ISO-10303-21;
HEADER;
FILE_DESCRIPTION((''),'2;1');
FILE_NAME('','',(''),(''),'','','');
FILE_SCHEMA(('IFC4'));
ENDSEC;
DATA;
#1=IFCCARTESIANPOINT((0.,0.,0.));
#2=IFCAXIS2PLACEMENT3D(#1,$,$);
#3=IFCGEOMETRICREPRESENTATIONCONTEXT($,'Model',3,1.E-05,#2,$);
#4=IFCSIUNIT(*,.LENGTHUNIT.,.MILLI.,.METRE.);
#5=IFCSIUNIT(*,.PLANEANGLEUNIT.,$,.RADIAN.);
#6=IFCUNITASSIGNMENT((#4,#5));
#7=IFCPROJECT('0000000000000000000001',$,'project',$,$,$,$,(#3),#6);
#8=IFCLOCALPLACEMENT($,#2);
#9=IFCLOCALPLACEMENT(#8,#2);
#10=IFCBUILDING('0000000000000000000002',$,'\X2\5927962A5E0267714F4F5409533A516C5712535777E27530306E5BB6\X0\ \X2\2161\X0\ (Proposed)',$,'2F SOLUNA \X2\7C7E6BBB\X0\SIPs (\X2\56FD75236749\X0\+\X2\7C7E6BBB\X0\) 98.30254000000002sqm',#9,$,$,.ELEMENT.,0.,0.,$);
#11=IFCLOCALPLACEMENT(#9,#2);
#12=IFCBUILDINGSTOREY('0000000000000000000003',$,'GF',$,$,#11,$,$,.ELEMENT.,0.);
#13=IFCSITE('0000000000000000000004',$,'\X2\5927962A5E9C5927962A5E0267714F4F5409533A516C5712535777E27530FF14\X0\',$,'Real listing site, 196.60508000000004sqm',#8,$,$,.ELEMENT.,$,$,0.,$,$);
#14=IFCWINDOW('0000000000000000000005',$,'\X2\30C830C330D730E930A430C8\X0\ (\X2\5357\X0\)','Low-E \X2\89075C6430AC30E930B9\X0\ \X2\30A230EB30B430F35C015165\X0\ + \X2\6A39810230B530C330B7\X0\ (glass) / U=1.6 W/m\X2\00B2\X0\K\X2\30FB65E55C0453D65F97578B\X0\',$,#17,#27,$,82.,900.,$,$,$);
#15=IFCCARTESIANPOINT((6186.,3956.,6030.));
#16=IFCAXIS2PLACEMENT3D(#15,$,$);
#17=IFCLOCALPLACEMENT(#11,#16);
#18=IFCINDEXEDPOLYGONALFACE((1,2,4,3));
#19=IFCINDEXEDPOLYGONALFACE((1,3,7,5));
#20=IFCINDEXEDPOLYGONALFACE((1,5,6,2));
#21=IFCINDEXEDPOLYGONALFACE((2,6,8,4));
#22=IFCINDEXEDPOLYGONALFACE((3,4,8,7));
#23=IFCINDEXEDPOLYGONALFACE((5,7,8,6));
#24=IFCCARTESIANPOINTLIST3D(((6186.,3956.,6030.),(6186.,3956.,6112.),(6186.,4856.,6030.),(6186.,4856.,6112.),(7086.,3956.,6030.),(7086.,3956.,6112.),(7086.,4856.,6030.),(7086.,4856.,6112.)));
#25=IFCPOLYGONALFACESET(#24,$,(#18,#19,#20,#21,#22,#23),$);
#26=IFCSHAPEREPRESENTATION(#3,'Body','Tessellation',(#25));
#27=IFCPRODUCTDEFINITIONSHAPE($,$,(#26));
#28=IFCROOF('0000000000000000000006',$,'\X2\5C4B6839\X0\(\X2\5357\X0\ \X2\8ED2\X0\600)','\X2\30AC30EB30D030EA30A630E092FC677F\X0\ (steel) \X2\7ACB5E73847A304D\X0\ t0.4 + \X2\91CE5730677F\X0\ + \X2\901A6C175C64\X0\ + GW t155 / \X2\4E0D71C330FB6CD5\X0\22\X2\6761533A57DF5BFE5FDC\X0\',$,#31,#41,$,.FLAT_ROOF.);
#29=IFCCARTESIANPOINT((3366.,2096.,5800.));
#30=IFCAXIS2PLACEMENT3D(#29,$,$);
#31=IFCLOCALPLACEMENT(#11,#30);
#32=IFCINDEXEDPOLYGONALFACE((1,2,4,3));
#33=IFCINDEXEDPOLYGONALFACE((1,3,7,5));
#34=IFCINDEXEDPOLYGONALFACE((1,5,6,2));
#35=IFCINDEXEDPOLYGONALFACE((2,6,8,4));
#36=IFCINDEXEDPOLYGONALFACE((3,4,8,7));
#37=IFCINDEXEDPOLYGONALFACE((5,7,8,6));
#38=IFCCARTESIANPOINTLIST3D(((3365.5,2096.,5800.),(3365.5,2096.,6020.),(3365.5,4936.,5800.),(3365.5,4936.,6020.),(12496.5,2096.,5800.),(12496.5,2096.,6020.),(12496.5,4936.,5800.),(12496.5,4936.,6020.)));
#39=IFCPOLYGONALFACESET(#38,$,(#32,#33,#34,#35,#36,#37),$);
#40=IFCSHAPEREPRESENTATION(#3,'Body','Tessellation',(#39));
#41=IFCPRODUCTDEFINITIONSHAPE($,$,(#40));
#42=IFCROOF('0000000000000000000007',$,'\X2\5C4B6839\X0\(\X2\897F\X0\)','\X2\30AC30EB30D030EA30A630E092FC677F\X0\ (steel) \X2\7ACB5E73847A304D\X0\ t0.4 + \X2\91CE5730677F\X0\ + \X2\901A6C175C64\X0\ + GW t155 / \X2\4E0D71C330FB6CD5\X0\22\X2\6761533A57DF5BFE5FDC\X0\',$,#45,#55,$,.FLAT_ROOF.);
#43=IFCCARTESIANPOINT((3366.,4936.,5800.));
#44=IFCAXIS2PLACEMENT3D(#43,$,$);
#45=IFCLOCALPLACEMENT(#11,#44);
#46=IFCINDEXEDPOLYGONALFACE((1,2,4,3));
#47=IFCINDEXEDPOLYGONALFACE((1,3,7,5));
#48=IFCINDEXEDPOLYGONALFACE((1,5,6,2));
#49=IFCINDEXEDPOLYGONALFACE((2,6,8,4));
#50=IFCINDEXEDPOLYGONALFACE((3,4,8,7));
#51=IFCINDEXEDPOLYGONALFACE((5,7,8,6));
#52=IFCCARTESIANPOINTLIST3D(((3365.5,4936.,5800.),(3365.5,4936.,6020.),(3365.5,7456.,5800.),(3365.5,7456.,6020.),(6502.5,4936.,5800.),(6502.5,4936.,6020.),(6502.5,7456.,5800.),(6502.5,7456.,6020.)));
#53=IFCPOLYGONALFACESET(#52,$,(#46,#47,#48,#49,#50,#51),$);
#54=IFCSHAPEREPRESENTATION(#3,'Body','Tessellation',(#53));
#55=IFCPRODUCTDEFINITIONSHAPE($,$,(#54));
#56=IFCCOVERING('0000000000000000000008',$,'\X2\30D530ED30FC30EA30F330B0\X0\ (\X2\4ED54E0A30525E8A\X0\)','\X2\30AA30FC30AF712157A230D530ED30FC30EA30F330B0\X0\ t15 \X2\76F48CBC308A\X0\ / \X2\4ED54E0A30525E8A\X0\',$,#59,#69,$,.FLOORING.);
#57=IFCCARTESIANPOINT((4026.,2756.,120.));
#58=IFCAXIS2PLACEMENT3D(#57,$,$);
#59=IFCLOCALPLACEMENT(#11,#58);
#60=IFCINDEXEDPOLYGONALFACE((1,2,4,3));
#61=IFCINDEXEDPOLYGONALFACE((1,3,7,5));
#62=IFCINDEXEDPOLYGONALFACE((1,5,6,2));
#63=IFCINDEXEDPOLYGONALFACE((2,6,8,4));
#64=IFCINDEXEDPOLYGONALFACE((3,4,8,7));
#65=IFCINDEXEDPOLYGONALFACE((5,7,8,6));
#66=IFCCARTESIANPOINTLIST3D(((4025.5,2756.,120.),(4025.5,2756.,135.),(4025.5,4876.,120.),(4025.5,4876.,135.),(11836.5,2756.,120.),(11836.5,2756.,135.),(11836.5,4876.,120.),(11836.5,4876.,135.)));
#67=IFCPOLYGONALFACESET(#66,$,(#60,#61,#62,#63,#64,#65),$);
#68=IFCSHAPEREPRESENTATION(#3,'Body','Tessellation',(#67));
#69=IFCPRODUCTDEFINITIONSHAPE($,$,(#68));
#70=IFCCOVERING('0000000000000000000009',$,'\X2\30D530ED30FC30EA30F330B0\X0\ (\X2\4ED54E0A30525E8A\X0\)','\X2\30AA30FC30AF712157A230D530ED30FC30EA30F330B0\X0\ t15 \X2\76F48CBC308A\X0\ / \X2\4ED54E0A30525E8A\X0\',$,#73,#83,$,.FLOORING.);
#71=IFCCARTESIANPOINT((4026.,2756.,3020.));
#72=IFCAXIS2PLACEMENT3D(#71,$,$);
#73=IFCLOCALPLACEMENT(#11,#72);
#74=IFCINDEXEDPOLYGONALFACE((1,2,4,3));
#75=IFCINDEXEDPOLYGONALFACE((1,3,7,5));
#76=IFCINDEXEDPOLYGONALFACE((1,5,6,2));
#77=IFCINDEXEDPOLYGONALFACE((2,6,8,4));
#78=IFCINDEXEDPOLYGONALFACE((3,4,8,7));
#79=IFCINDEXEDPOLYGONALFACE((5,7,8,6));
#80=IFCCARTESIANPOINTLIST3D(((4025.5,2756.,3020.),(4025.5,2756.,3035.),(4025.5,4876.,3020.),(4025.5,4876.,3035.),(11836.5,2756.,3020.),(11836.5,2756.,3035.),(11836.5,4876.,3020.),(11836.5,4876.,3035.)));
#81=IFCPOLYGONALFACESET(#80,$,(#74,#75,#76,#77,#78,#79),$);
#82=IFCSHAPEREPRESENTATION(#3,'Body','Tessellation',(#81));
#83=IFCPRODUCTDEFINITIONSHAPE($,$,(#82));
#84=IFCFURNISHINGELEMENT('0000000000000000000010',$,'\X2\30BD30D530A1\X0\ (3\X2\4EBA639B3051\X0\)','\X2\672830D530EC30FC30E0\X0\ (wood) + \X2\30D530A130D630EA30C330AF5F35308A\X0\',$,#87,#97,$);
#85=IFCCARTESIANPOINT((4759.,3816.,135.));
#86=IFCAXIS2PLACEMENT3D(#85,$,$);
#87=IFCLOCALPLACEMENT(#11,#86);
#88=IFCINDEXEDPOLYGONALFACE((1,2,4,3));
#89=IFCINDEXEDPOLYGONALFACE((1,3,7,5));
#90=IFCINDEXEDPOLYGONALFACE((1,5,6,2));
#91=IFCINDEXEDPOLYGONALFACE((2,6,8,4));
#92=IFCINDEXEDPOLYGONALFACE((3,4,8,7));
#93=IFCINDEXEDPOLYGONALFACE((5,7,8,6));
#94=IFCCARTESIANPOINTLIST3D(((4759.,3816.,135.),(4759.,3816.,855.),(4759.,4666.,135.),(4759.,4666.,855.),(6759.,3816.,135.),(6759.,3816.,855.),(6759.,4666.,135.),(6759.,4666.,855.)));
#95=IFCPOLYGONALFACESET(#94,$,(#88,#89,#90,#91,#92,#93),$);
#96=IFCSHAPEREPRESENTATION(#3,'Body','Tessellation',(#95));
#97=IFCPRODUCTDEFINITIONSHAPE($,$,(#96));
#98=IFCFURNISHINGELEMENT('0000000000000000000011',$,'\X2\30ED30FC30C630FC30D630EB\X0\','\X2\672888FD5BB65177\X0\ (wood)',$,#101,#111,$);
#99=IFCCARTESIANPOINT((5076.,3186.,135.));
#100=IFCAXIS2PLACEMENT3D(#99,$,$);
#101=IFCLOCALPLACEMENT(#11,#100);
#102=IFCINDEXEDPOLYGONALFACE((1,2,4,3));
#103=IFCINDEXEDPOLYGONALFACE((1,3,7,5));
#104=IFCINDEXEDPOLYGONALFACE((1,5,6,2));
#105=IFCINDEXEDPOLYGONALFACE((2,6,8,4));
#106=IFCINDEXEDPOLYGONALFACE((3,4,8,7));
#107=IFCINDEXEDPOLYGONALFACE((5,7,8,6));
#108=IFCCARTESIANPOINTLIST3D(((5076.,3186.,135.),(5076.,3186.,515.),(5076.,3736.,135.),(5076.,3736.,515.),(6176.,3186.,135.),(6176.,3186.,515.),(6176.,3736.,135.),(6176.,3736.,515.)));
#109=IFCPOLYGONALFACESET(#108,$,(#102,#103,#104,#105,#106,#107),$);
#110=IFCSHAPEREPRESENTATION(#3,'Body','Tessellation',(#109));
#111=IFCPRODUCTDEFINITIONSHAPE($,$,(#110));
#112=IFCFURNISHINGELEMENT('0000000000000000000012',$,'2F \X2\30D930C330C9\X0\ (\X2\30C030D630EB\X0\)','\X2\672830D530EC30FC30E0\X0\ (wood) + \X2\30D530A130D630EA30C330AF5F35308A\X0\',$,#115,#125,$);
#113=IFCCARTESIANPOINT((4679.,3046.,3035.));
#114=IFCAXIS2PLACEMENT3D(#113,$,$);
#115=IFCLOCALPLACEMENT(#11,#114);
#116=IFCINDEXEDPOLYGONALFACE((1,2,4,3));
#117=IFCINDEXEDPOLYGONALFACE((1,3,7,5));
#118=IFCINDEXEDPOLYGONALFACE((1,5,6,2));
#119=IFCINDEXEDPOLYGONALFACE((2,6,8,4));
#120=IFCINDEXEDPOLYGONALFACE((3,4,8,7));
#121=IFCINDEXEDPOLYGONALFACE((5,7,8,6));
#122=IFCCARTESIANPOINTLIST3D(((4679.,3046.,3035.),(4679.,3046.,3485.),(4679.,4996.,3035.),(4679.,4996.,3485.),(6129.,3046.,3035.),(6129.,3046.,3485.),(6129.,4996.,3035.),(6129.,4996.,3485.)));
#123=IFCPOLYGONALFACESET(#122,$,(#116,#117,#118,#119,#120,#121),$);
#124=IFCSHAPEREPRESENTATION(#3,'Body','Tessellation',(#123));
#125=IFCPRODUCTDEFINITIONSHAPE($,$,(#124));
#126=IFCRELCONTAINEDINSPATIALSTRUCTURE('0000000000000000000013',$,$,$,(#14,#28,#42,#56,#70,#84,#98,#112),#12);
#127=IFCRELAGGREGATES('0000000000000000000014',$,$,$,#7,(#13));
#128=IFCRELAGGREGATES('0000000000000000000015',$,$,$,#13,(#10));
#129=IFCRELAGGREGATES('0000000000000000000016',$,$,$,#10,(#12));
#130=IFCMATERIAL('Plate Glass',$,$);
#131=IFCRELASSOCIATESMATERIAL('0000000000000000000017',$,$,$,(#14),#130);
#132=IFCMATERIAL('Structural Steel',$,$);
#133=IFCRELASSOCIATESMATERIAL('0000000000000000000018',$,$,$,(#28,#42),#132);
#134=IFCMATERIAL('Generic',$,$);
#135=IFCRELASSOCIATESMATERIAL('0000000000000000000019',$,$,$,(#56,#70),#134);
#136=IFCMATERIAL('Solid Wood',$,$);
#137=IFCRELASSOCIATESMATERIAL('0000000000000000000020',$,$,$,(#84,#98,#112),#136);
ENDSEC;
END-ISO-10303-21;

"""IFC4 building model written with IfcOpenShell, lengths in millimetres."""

from ifc_helpers import new_model, si_unit, frame, frame_2d, origin, place, context, project, spatial, rectangle, extrude, material, element, save


model = new_model("IFC4")

# Units and contexts
model_context = context("Model", 3, precision=1e-05, world=origin())
ifc_project = project(units=[si_unit("LENGTHUNIT", "METRE", prefix="MILLI"), si_unit("PLANEANGLEUNIT", "RADIAN")], contexts=[model_context])

# Site, building, storey
site_placement = place(None, origin())
site = spatial("IfcSite", under=ifc_project, at=site_placement, Name="大阪府大阪市東住吉区公園南矢田４", ObjectType="Real listing site, 196.60508000000004sqm", CompositionType="ELEMENT", RefElevation=0.0)
building_placement = place(site_placement, origin())
building = spatial("IfcBuilding", under=site, at=building_placement, Name="大阪市東住吉区公園南矢田の家 Ⅱ (Proposed)", ObjectType="2F SOLUNA 籾殻SIPs (国産杉+籾殻) 98.30254000000002sqm", CompositionType="ELEMENT", ElevationOfRefHeight=0.0, ElevationOfTerrain=0.0)
storey_placement = place(building_placement, origin())
storey = spatial("IfcBuildingStorey", under=building, at=storey_placement, Name="GF", CompositionType="ELEMENT", Elevation=0.0)

# Shared definitions
ifc_material_1 = material(Name="Solid Wood")

# Shared definitions
ifc_material_2 = material(Name="Plate Glass")

# Window
window_1_placement = place(storey_placement, frame((6186.0, 3956.0, 6030.0)))
element("IfcWindow", 1, at=window_1_placement, inside=storey, material=ifc_material_2, Name="トップライト (南)", Description="Low-E 複層ガラス アルゴン封入 + 樹脂サッシ (glass) / U=1.6 W/m²K・日射取得型", OverallHeight=82.0, OverallWidth=900.0, context=model_context, shape_type="SweptSolid", body=[
    extrude(rectangle(XDim=900.0, YDim=900.0, at=frame_2d((450.0, 450.0))), frame((6186.0, 3956.0, 6030.0)), (0.0, 0.0, 1.0), 82.0),
])

# Roofs
ifc_material_3 = material(Name="Structural Steel")
roof_1_placement = place(storey_placement, frame((3366.0, 2096.0, 5800.0)))
element("IfcRoof", 2, at=roof_1_placement, inside=storey, material=ifc_material_3, Name="屋根(南 軒600)", Description="ガルバリウム鋼板 (steel) 立平葺き t0.4 + 野地板 + 通気層 + GW t155 / 不燃・法22条区域対応", PredefinedType="FLAT_ROOF", context=model_context, shape_type="SweptSolid", body=[
    extrude(rectangle(XDim=9131.0, YDim=2840.0, at=frame_2d((4565.0, 1420.0))), frame((3366.0, 2096.0, 5800.0)), (0.0, 0.0, 1.0), 220.0),
])
roof_2_placement = place(storey_placement, frame((3366.0, 4936.0, 5800.0)))
element("IfcRoof", 3, at=roof_2_placement, inside=storey, material=ifc_material_3, Name="屋根(西)", Description="ガルバリウム鋼板 (steel) 立平葺き t0.4 + 野地板 + 通気層 + GW t155 / 不燃・法22条区域対応", PredefinedType="FLAT_ROOF", context=model_context, shape_type="SweptSolid", body=[
    extrude(rectangle(XDim=3137.0, YDim=2520.0, at=frame_2d((1568.0, 1260.0))), frame((3366.0, 4936.0, 5800.0)), (0.0, 0.0, 1.0), 220.0),
])

# Coverings
ifc_material_4 = material(Name="Generic")
covering_1_placement = place(storey_placement, frame((4026.0, 2756.0, 120.0)))
element("IfcCovering", 4, at=covering_1_placement, inside=storey, material=ifc_material_4, Name="フローリング (仕上げ床)", Description="オーク無垢フローリング t15 直貼り / 仕上げ床", PredefinedType="FLOORING", context=model_context, shape_type="SweptSolid", body=[
    extrude(rectangle(XDim=7811.0, YDim=2120.0, at=frame_2d((3905.0, 1060.0))), frame((4026.0, 2756.0, 120.0)), (0.0, 0.0, 1.0), 15.0),
])
covering_2_placement = place(storey_placement, frame((4026.0, 2756.0, 3020.0)))
element("IfcCovering", 5, at=covering_2_placement, inside=storey, material=ifc_material_4, Name="フローリング (仕上げ床)", Description="オーク無垢フローリング t15 直貼り / 仕上げ床", PredefinedType="FLOORING", context=model_context, shape_type="SweptSolid", body=[
    extrude(rectangle(XDim=7811.0, YDim=2120.0, at=frame_2d((3905.0, 1060.0))), frame((4026.0, 2756.0, 3020.0)), (0.0, 0.0, 1.0), 15.0),
])

# Furnishing elements
furnishing_1_placement = place(storey_placement, frame((4759.0, 3816.0, 135.0)))
element("IfcFurnishingElement", 6, at=furnishing_1_placement, inside=storey, material=ifc_material_1, Name="ソファ (3人掛け)", Description="木フレーム (wood) + ファブリック張り", context=model_context, shape_type="SweptSolid", body=[
    extrude(rectangle(XDim=2000.0, YDim=850.0, at=frame_2d((1000.0, 425.0))), frame((4759.0, 3816.0, 135.0)), (0.0, 0.0, 1.0), 720.0),
])
furnishing_2_placement = place(storey_placement, frame((5076.0, 3186.0, 135.0)))
element("IfcFurnishingElement", 7, at=furnishing_2_placement, inside=storey, material=ifc_material_1, Name="ローテーブル", Description="木製家具 (wood)", context=model_context, shape_type="SweptSolid", body=[
    extrude(rectangle(XDim=1100.0, YDim=550.0, at=frame_2d((550.0, 275.0))), frame((5076.0, 3186.0, 135.0)), (0.0, 0.0, 1.0), 380.0),
])
furnishing_3_placement = place(storey_placement, frame((4679.0, 3046.0, 3035.0)))
element("IfcFurnishingElement", 8, at=furnishing_3_placement, inside=storey, material=ifc_material_1, Name="2F ベッド (ダブル)", Description="木フレーム (wood) + ファブリック張り", context=model_context, shape_type="SweptSolid", body=[
    extrude(rectangle(XDim=1450.0, YDim=1950.0, at=frame_2d((725.0, 975.0))), frame((4679.0, 3046.0, 3035.0)), (0.0, 0.0, 1.0), 450.0),
])

save(model, "model.ifc")
